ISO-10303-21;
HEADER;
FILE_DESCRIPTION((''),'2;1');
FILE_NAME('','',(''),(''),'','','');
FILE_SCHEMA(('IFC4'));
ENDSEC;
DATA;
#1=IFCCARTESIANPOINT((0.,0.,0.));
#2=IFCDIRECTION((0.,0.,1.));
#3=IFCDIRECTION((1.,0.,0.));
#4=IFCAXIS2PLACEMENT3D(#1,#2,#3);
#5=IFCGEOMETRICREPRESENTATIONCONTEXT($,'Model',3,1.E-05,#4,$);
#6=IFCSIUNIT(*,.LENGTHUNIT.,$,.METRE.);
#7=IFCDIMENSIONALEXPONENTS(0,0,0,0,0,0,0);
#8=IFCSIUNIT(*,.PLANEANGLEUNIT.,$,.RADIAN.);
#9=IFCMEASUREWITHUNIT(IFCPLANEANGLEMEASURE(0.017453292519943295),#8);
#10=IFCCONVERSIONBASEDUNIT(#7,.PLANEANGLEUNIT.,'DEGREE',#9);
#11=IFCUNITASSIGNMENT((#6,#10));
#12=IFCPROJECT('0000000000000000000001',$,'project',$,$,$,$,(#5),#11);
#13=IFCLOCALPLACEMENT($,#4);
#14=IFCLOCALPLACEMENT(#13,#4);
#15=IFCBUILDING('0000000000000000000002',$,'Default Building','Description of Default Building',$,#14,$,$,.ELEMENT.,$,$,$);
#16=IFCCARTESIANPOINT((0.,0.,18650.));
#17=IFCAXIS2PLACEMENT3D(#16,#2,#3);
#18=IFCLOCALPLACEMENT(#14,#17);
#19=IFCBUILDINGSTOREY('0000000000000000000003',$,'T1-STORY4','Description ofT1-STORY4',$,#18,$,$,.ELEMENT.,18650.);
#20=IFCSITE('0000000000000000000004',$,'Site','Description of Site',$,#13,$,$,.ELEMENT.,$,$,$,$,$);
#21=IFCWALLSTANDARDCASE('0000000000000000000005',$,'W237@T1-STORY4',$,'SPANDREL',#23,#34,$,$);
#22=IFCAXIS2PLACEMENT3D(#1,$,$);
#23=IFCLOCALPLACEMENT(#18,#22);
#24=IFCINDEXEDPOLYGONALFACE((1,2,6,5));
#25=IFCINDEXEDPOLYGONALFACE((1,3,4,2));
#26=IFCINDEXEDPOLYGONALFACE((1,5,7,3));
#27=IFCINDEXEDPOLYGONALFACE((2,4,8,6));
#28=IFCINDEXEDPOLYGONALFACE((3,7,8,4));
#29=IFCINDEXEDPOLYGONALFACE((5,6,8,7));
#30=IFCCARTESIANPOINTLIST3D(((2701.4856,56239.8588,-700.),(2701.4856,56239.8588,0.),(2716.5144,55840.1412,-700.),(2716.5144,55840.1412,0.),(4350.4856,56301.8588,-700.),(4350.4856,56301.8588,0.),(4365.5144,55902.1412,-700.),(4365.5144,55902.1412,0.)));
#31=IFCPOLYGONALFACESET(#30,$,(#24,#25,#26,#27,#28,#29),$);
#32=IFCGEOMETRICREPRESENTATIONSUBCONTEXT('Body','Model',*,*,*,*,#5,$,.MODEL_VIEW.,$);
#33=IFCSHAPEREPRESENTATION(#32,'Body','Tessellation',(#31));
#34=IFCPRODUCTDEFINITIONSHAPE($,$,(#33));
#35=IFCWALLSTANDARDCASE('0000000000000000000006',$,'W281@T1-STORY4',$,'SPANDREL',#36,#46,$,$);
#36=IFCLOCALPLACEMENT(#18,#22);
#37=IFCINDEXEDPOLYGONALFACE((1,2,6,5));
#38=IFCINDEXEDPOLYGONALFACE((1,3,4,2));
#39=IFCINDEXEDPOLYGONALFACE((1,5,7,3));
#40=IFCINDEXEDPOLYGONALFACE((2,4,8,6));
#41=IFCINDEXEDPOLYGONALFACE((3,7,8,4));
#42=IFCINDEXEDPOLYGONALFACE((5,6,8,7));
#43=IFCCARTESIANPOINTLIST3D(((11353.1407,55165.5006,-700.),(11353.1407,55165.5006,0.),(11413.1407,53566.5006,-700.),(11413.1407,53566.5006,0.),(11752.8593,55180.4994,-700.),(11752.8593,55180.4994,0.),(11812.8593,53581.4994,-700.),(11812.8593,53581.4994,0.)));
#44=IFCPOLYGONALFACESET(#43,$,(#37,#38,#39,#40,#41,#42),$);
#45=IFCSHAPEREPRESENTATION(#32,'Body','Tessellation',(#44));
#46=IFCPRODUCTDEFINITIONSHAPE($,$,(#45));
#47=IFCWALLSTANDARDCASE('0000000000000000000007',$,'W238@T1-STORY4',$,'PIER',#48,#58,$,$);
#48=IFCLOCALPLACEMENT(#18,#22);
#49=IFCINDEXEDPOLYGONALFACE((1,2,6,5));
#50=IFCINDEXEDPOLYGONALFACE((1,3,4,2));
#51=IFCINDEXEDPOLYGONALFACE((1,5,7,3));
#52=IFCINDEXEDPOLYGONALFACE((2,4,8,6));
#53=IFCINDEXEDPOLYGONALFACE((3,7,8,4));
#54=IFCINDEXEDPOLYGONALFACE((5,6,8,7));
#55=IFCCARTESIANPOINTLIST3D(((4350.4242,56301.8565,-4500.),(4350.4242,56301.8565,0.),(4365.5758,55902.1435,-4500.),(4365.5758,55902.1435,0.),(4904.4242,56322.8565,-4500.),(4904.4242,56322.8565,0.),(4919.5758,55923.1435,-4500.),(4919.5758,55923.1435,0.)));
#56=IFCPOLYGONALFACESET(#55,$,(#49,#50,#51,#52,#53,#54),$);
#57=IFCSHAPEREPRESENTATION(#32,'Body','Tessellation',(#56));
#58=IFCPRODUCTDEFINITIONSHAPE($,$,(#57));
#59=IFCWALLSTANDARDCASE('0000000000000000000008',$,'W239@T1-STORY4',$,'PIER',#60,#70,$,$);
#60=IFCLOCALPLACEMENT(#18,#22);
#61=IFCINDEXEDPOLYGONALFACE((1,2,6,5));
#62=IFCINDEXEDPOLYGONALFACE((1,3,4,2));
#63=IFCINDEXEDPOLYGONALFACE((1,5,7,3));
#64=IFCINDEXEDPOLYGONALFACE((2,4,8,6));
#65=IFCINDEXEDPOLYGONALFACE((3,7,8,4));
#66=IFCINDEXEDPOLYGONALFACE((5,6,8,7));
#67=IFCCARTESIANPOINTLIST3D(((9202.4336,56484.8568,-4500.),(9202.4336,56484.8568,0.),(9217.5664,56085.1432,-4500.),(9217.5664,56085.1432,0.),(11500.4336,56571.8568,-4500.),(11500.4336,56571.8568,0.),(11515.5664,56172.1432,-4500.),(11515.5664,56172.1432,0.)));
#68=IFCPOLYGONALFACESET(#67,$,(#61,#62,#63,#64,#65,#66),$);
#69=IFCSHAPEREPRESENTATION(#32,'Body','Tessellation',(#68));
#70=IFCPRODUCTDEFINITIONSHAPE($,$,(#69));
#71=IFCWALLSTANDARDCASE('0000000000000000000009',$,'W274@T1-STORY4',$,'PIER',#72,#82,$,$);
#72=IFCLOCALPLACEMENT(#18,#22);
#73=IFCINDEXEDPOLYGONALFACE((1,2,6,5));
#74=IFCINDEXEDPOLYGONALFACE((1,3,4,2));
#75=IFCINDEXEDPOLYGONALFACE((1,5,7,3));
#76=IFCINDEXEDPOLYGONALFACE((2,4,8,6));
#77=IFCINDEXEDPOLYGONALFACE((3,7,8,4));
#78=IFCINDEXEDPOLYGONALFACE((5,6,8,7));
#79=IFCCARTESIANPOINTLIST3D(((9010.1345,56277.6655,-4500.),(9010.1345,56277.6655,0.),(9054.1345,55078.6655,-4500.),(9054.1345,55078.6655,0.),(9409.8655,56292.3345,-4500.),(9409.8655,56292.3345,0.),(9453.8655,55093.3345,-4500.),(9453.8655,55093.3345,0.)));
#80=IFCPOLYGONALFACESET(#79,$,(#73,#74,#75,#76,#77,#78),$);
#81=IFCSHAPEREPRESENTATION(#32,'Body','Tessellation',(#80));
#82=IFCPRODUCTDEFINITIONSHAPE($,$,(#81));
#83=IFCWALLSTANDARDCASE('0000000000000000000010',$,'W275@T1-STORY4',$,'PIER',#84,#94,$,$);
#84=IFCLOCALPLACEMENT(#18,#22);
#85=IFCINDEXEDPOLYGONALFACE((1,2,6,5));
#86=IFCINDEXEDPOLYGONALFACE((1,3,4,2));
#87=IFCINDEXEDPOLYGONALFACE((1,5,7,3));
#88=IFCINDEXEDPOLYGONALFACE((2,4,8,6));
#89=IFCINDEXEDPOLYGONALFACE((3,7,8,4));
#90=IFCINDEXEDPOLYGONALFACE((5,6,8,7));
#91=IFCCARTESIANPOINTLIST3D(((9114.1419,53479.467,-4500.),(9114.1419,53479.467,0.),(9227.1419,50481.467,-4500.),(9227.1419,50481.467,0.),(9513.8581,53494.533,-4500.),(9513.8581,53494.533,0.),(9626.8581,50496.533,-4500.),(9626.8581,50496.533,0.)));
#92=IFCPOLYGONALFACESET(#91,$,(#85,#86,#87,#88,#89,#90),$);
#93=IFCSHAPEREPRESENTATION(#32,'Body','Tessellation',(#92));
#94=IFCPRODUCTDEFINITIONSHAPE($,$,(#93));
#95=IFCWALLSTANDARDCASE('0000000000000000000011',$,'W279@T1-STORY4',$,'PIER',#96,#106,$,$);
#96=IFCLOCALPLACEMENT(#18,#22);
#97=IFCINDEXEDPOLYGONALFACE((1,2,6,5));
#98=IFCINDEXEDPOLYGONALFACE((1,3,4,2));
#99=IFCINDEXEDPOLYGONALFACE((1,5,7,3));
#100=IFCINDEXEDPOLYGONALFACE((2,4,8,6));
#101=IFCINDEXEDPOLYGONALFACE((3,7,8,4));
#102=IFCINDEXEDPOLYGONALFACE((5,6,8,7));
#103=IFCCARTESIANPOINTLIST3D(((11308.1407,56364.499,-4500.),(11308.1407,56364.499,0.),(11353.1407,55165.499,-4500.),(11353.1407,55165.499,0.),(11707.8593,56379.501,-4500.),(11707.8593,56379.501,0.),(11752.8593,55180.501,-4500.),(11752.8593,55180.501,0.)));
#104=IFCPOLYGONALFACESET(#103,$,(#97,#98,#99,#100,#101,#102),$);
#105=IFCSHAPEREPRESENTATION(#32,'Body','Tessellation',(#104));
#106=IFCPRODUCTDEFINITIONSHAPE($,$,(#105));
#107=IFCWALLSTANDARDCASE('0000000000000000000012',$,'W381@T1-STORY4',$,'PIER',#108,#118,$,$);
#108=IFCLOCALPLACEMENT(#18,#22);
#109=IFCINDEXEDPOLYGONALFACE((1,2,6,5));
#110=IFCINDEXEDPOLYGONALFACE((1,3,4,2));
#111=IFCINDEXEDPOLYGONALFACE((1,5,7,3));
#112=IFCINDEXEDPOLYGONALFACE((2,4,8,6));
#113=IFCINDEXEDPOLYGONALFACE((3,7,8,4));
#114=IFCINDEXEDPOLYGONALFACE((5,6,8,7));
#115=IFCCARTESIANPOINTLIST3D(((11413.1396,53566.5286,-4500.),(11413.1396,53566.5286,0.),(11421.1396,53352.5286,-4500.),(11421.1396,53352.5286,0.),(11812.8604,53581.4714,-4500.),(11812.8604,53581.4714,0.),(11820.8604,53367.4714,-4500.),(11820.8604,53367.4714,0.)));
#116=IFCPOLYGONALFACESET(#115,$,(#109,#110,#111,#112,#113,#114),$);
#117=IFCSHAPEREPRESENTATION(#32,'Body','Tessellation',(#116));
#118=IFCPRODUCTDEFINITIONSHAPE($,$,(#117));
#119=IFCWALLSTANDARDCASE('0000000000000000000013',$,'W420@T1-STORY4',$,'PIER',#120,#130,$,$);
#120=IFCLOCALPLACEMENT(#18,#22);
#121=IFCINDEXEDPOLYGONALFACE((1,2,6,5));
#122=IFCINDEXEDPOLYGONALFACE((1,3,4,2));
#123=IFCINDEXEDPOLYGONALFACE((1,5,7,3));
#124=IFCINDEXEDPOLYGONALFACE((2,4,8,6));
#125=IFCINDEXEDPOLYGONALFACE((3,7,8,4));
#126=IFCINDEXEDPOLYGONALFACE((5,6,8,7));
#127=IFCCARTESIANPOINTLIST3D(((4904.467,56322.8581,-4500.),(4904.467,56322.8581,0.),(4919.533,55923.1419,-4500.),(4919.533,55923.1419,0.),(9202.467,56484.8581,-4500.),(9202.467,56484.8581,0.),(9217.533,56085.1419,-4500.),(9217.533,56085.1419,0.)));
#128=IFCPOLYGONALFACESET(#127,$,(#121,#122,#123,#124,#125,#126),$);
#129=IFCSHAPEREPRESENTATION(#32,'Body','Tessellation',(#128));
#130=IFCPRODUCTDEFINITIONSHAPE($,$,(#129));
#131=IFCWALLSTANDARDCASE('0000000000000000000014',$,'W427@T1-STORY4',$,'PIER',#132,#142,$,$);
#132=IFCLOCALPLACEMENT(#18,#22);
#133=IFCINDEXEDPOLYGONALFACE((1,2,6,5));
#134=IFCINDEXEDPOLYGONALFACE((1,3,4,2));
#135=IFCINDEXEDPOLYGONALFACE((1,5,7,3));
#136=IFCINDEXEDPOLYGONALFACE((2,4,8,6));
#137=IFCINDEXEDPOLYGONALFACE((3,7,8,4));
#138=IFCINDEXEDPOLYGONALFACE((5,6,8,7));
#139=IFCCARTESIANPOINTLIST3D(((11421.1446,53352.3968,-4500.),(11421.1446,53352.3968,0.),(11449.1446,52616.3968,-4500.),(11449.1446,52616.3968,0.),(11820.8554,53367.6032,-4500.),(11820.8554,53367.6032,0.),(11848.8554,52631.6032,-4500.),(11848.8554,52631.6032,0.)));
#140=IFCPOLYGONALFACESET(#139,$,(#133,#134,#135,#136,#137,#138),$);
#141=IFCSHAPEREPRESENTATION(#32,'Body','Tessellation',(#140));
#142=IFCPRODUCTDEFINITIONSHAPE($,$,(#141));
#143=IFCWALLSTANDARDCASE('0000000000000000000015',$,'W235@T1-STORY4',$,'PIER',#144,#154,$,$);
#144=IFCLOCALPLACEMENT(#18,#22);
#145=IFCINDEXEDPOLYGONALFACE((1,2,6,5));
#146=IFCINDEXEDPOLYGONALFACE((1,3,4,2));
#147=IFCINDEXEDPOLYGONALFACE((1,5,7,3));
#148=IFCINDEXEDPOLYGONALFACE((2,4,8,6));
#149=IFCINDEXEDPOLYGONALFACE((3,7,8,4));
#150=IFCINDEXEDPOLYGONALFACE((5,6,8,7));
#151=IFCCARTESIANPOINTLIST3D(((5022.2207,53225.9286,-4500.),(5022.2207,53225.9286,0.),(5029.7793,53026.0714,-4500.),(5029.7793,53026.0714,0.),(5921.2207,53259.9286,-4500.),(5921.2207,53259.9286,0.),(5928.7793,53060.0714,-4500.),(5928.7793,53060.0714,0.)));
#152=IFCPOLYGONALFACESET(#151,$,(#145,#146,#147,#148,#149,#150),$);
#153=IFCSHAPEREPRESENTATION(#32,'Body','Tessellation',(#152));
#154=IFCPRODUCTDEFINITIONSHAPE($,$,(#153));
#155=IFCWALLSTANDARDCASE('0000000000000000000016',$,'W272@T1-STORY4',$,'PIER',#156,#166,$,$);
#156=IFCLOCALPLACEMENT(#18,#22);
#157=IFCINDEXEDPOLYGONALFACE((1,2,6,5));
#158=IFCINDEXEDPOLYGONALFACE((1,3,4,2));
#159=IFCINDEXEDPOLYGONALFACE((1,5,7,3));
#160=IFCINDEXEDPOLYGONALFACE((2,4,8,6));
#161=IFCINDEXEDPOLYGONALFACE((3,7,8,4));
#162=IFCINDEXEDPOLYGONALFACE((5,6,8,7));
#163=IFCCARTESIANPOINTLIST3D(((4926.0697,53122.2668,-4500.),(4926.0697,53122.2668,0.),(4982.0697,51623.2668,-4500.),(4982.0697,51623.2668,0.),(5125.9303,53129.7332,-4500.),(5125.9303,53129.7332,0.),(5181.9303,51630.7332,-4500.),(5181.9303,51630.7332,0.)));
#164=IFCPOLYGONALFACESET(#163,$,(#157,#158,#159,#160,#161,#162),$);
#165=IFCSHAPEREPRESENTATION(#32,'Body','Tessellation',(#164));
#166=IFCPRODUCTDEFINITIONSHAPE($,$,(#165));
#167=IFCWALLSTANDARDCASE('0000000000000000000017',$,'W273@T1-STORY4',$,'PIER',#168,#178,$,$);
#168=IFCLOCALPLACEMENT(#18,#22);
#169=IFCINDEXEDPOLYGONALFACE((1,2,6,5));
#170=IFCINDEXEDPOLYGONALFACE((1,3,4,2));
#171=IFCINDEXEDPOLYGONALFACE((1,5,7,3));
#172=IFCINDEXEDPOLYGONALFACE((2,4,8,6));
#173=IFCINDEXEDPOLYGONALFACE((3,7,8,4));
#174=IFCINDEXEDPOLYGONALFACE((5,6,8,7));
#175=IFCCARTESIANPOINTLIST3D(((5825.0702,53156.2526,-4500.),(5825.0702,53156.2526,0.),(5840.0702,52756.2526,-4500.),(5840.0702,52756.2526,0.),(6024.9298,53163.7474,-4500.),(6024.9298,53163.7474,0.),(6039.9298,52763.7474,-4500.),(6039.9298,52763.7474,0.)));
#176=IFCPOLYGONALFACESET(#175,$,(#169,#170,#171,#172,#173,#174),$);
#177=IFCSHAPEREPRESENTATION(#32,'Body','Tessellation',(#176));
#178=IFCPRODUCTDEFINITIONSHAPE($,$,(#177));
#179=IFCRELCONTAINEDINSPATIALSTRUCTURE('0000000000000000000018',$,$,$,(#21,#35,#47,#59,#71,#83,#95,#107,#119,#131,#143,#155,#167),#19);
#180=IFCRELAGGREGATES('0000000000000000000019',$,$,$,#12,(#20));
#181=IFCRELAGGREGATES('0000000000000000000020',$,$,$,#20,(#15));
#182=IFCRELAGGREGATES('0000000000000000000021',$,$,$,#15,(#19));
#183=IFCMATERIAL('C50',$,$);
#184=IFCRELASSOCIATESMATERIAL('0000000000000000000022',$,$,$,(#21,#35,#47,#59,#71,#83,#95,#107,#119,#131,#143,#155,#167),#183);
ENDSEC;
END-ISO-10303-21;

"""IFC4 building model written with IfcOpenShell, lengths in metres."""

from ifc_helpers import new_model, entity, si_unit, converted_unit, frame, origin_with_axes, place, context, subcontext, project, spatial, indexed_curve, outline, extrude, material, element, save


model = new_model("IFC4")

# Units and contexts
model_context = context("Model", 3, precision=1e-05, world=origin_with_axes())
body_context = subcontext(model_context, "Body", "Model", "MODEL_VIEW")
ifc_project = project(units=[si_unit("LENGTHUNIT", "METRE"), converted_unit("PLANEANGLEUNIT", "DEGREE", entity("IfcPlaneAngleMeasure", 0.017453292519943295), si_unit("PLANEANGLEUNIT", "RADIAN"), dimensions=[0, 0, 0, 0, 0, 0, 0])], contexts=[model_context])

# Site, building, storey
site_placement = place(None, origin_with_axes())
site = spatial("IfcSite", under=ifc_project, at=site_placement, Name="Site", Description="Description of Site", CompositionType="ELEMENT")
building_placement = place(site_placement, origin_with_axes())
building = spatial("IfcBuilding", under=site, at=building_placement, Name="Default Building", Description="Description of Default Building", CompositionType="ELEMENT")
storey_placement = place(building_placement, frame((0.0, 0.0, 18650.0), z_axis=(0.0, 0.0, 1.0), x_axis=(1.0, 0.0, 0.0)))
storey = spatial("IfcBuildingStorey", under=building, at=storey_placement, Name="T1-STORY4", Description="Description ofT1-STORY4", CompositionType="ELEMENT", Elevation=18650.0)

# Shared definitions
ifc_material_1 = material(Name="C50")

# Walls
wall_1_placement = place(storey_placement, frame((2709.0, 56040.0, -700.0), z_axis=(0.0, 0.0, 1.0), x_axis=(0.999294, 0.037572, 0.0)))
element("IfcWallStandardCase", 1, at=wall_1_placement, inside=storey, material=ifc_material_1, Name="W237@T1-STORY4", ObjectType="SPANDREL", context=body_context, shape_type="SweptSolid", body=[
    extrude(outline(indexed_curve([(0.0, -200.0), (0.0, 200.0), (1650.1651, 200.0), (1650.1651, -200.0), (0.0, -200.0)], self_intersect=False)), origin_with_axes(), (0.0, 0.0, 1.0), 700.0),
])
wall_2_placement = place(storey_placement, frame((11553.0, 55173.0, -700.0), z_axis=(0.0, 0.0, 1.0), x_axis=(0.037497, -0.999297, 0.0)))
element("IfcWallStandardCase", 2, at=wall_2_placement, inside=storey, material=ifc_material_1, Name="W281@T1-STORY4", ObjectType="SPANDREL", context=body_context, shape_type="SweptSolid", body=[
    extrude(outline(indexed_curve([(0.0, -200.0), (0.0, 200.0), (1600.1253, 200.0), (1600.1253, -200.0), (0.0, -200.0)], self_intersect=False)), origin_with_axes(), (0.0, 0.0, 1.0), 700.0),
])
wall_3_placement = place(storey_placement, frame((4358.0, 56102.0, -4500.0), z_axis=(0.0, 0.0, 1.0), x_axis=(0.999282, 0.037879, 0.0)))
element("IfcWallStandardCase", 3, at=wall_3_placement, inside=storey, material=ifc_material_1, Name="W238@T1-STORY4", ObjectType="PIER", context=body_context, shape_type="SweptSolid", body=[
    extrude(outline(indexed_curve([(0.0, -200.0), (0.0, 200.0), (554.3979, 200.0), (554.3979, -200.0), (0.0, -200.0)], self_intersect=False)), origin_with_axes(), (0.0, 0.0, 1.0), 4500.0),
])
wall_4_placement = place(storey_placement, frame((9210.0, 56285.0, -4500.0), z_axis=(0.0, 0.0, 1.0), x_axis=(0.999284, 0.037832, 0.0)))
element("IfcWallStandardCase", 4, at=wall_4_placement, inside=storey, material=ifc_material_1, Name="W239@T1-STORY4", ObjectType="PIER", context=body_context, shape_type="SweptSolid", body=[
    extrude(outline(indexed_curve([(0.0, -200.0), (0.0, 200.0), (2299.6463, 200.0), (2299.6463, -200.0), (0.0, -200.0)], self_intersect=False)), origin_with_axes(), (0.0, 0.0, 1.0), 4500.0),
])
wall_5_placement = place(storey_placement, frame((9210.0, 56285.0, -4500.0), z_axis=(0.0, 0.0, 1.0), x_axis=(0.036673, -0.999327, 0.0)))
element("IfcWallStandardCase", 5, at=wall_5_placement, inside=storey, material=ifc_material_1, Name="W274@T1-STORY4", ObjectType="PIER", context=body_context, shape_type="SweptSolid", body=[
    extrude(outline(indexed_curve([(0.0, -200.0), (0.0, 200.0), (1199.8071, 200.0), (1199.8071, -200.0), (0.0, -200.0)], self_intersect=False)), origin_with_axes(), (0.0, 0.0, 1.0), 4500.0),
])
wall_6_placement = place(storey_placement, frame((9314.0, 53487.0, -4500.0), z_axis=(0.0, 0.0, 1.0), x_axis=(0.037665, -0.99929, 0.0)))
element("IfcWallStandardCase", 6, at=wall_6_placement, inside=storey, material=ifc_material_1, Name="W275@T1-STORY4", ObjectType="PIER", context=body_context, shape_type="SweptSolid", body=[
    extrude(outline(indexed_curve([(0.0, -200.0), (0.0, 200.0), (3000.1288, 200.0), (3000.1288, -200.0), (0.0, -200.0)], self_intersect=False)), origin_with_axes(), (0.0, 0.0, 1.0), 4500.0),
])
wall_7_placement = place(storey_placement, frame((11508.0, 56372.0, -4500.0), z_axis=(0.0, 0.0, 1.0), x_axis=(0.037505, -0.999296, 0.0)))
element("IfcWallStandardCase", 7, at=wall_7_placement, inside=storey, material=ifc_material_1, Name="W279@T1-STORY4", ObjectType="PIER", context=body_context, shape_type="SweptSolid", body=[
    extrude(outline(indexed_curve([(0.0, -200.0), (0.0, 200.0), (1199.8442, 200.0), (1199.8442, -200.0), (0.0, -200.0)], self_intersect=False)), origin_with_axes(), (0.0, 0.0, 1.0), 4500.0),
])
wall_8_placement = place(storey_placement, frame((11613.0, 53574.0, -4500.0), z_axis=(0.0, 0.0, 1.0), x_axis=(0.037357, -0.999302, 0.0)))
element("IfcWallStandardCase", 8, at=wall_8_placement, inside=storey, material=ifc_material_1, Name="W381@T1-STORY4", ObjectType="PIER", context=body_context, shape_type="SweptSolid", body=[
    extrude(outline(indexed_curve([(0.0, -200.0), (0.0, 200.0), (214.1495, 200.0), (214.1495, -200.0), (0.0, -200.0)], self_intersect=False)), origin_with_axes(), (0.0, 0.0, 1.0), 4500.0),
])
wall_9_placement = place(storey_placement, frame((4912.0, 56123.0, -4500.0), z_axis=(0.0, 0.0, 1.0), x_axis=(0.99929, 0.037665, 0.0)))
element("IfcWallStandardCase", 9, at=wall_9_placement, inside=storey, material=ifc_material_1, Name="W420@T1-STORY4", ObjectType="PIER", context=body_context, shape_type="SweptSolid", body=[
    extrude(outline(indexed_curve([(0.0, -200.0), (0.0, 200.0), (4301.052, 200.0), (4301.052, -200.0), (0.0, -200.0)], self_intersect=False)), origin_with_axes(), (0.0, 0.0, 1.0), 4500.0),
])
wall_10_placement = place(storey_placement, frame((11621.0, 53360.0, -4500.0), z_axis=(0.0, 0.0, 1.0), x_axis=(0.038016, -0.999277, 0.0)))
element("IfcWallStandardCase", 10, at=wall_10_placement, inside=storey, material=ifc_material_1, Name="W427@T1-STORY4", ObjectType="PIER", context=body_context, shape_type="SweptSolid", body=[
    extrude(outline(indexed_curve([(0.0, -200.0), (0.0, 200.0), (736.5324, 200.0), (736.5324, -200.0), (0.0, -200.0)], self_intersect=False)), origin_with_axes(), (0.0, 0.0, 1.0), 4500.0),
])
wall_11_placement = place(storey_placement, frame((5026.0, 53126.0, -4500.0), z_axis=(0.0, 0.0, 1.0), x_axis=(0.999286, 0.037793, 0.0)))
element("IfcWallStandardCase", 11, at=wall_11_placement, inside=storey, material=ifc_material_1, Name="W235@T1-STORY4", ObjectType="PIER", context=body_context, shape_type="SweptSolid", body=[
    extrude(outline(indexed_curve([(0.0, -100.0), (0.0, 100.0), (899.6427, 100.0), (899.6427, -100.0), (0.0, -100.0)], self_intersect=False)), origin_with_axes(), (0.0, 0.0, 1.0), 4500.0),
])
wall_12_placement = place(storey_placement, frame((5026.0, 53126.0, -4500.0), z_axis=(0.0, 0.0, 1.0), x_axis=(0.037332, -0.999303, 0.0)))
element("IfcWallStandardCase", 12, at=wall_12_placement, inside=storey, material=ifc_material_1, Name="W272@T1-STORY4", ObjectType="PIER", context=body_context, shape_type="SweptSolid", body=[
    extrude(outline(indexed_curve([(0.0, -100.0), (0.0, 100.0), (1500.0457, 100.0), (1500.0457, -100.0), (0.0, -100.0)], self_intersect=False)), origin_with_axes(), (0.0, 0.0, 1.0), 4500.0),
])
wall_13_placement = place(storey_placement, frame((5925.0, 53160.0, -4500.0), z_axis=(0.0, 0.0, 1.0), x_axis=(0.037474, -0.999298, 0.0)))
element("IfcWallStandardCase", 13, at=wall_13_placement, inside=storey, material=ifc_material_1, Name="W273@T1-STORY4", ObjectType="PIER", context=body_context, shape_type="SweptSolid", body=[
    extrude(outline(indexed_curve([(0.0, -100.0), (0.0, 100.0), (400.2812, 100.0), (400.2812, -100.0), (0.0, -100.0)], self_intersect=False)), origin_with_axes(), (0.0, 0.0, 1.0), 4500.0),
])

save(model, "model.ifc")
